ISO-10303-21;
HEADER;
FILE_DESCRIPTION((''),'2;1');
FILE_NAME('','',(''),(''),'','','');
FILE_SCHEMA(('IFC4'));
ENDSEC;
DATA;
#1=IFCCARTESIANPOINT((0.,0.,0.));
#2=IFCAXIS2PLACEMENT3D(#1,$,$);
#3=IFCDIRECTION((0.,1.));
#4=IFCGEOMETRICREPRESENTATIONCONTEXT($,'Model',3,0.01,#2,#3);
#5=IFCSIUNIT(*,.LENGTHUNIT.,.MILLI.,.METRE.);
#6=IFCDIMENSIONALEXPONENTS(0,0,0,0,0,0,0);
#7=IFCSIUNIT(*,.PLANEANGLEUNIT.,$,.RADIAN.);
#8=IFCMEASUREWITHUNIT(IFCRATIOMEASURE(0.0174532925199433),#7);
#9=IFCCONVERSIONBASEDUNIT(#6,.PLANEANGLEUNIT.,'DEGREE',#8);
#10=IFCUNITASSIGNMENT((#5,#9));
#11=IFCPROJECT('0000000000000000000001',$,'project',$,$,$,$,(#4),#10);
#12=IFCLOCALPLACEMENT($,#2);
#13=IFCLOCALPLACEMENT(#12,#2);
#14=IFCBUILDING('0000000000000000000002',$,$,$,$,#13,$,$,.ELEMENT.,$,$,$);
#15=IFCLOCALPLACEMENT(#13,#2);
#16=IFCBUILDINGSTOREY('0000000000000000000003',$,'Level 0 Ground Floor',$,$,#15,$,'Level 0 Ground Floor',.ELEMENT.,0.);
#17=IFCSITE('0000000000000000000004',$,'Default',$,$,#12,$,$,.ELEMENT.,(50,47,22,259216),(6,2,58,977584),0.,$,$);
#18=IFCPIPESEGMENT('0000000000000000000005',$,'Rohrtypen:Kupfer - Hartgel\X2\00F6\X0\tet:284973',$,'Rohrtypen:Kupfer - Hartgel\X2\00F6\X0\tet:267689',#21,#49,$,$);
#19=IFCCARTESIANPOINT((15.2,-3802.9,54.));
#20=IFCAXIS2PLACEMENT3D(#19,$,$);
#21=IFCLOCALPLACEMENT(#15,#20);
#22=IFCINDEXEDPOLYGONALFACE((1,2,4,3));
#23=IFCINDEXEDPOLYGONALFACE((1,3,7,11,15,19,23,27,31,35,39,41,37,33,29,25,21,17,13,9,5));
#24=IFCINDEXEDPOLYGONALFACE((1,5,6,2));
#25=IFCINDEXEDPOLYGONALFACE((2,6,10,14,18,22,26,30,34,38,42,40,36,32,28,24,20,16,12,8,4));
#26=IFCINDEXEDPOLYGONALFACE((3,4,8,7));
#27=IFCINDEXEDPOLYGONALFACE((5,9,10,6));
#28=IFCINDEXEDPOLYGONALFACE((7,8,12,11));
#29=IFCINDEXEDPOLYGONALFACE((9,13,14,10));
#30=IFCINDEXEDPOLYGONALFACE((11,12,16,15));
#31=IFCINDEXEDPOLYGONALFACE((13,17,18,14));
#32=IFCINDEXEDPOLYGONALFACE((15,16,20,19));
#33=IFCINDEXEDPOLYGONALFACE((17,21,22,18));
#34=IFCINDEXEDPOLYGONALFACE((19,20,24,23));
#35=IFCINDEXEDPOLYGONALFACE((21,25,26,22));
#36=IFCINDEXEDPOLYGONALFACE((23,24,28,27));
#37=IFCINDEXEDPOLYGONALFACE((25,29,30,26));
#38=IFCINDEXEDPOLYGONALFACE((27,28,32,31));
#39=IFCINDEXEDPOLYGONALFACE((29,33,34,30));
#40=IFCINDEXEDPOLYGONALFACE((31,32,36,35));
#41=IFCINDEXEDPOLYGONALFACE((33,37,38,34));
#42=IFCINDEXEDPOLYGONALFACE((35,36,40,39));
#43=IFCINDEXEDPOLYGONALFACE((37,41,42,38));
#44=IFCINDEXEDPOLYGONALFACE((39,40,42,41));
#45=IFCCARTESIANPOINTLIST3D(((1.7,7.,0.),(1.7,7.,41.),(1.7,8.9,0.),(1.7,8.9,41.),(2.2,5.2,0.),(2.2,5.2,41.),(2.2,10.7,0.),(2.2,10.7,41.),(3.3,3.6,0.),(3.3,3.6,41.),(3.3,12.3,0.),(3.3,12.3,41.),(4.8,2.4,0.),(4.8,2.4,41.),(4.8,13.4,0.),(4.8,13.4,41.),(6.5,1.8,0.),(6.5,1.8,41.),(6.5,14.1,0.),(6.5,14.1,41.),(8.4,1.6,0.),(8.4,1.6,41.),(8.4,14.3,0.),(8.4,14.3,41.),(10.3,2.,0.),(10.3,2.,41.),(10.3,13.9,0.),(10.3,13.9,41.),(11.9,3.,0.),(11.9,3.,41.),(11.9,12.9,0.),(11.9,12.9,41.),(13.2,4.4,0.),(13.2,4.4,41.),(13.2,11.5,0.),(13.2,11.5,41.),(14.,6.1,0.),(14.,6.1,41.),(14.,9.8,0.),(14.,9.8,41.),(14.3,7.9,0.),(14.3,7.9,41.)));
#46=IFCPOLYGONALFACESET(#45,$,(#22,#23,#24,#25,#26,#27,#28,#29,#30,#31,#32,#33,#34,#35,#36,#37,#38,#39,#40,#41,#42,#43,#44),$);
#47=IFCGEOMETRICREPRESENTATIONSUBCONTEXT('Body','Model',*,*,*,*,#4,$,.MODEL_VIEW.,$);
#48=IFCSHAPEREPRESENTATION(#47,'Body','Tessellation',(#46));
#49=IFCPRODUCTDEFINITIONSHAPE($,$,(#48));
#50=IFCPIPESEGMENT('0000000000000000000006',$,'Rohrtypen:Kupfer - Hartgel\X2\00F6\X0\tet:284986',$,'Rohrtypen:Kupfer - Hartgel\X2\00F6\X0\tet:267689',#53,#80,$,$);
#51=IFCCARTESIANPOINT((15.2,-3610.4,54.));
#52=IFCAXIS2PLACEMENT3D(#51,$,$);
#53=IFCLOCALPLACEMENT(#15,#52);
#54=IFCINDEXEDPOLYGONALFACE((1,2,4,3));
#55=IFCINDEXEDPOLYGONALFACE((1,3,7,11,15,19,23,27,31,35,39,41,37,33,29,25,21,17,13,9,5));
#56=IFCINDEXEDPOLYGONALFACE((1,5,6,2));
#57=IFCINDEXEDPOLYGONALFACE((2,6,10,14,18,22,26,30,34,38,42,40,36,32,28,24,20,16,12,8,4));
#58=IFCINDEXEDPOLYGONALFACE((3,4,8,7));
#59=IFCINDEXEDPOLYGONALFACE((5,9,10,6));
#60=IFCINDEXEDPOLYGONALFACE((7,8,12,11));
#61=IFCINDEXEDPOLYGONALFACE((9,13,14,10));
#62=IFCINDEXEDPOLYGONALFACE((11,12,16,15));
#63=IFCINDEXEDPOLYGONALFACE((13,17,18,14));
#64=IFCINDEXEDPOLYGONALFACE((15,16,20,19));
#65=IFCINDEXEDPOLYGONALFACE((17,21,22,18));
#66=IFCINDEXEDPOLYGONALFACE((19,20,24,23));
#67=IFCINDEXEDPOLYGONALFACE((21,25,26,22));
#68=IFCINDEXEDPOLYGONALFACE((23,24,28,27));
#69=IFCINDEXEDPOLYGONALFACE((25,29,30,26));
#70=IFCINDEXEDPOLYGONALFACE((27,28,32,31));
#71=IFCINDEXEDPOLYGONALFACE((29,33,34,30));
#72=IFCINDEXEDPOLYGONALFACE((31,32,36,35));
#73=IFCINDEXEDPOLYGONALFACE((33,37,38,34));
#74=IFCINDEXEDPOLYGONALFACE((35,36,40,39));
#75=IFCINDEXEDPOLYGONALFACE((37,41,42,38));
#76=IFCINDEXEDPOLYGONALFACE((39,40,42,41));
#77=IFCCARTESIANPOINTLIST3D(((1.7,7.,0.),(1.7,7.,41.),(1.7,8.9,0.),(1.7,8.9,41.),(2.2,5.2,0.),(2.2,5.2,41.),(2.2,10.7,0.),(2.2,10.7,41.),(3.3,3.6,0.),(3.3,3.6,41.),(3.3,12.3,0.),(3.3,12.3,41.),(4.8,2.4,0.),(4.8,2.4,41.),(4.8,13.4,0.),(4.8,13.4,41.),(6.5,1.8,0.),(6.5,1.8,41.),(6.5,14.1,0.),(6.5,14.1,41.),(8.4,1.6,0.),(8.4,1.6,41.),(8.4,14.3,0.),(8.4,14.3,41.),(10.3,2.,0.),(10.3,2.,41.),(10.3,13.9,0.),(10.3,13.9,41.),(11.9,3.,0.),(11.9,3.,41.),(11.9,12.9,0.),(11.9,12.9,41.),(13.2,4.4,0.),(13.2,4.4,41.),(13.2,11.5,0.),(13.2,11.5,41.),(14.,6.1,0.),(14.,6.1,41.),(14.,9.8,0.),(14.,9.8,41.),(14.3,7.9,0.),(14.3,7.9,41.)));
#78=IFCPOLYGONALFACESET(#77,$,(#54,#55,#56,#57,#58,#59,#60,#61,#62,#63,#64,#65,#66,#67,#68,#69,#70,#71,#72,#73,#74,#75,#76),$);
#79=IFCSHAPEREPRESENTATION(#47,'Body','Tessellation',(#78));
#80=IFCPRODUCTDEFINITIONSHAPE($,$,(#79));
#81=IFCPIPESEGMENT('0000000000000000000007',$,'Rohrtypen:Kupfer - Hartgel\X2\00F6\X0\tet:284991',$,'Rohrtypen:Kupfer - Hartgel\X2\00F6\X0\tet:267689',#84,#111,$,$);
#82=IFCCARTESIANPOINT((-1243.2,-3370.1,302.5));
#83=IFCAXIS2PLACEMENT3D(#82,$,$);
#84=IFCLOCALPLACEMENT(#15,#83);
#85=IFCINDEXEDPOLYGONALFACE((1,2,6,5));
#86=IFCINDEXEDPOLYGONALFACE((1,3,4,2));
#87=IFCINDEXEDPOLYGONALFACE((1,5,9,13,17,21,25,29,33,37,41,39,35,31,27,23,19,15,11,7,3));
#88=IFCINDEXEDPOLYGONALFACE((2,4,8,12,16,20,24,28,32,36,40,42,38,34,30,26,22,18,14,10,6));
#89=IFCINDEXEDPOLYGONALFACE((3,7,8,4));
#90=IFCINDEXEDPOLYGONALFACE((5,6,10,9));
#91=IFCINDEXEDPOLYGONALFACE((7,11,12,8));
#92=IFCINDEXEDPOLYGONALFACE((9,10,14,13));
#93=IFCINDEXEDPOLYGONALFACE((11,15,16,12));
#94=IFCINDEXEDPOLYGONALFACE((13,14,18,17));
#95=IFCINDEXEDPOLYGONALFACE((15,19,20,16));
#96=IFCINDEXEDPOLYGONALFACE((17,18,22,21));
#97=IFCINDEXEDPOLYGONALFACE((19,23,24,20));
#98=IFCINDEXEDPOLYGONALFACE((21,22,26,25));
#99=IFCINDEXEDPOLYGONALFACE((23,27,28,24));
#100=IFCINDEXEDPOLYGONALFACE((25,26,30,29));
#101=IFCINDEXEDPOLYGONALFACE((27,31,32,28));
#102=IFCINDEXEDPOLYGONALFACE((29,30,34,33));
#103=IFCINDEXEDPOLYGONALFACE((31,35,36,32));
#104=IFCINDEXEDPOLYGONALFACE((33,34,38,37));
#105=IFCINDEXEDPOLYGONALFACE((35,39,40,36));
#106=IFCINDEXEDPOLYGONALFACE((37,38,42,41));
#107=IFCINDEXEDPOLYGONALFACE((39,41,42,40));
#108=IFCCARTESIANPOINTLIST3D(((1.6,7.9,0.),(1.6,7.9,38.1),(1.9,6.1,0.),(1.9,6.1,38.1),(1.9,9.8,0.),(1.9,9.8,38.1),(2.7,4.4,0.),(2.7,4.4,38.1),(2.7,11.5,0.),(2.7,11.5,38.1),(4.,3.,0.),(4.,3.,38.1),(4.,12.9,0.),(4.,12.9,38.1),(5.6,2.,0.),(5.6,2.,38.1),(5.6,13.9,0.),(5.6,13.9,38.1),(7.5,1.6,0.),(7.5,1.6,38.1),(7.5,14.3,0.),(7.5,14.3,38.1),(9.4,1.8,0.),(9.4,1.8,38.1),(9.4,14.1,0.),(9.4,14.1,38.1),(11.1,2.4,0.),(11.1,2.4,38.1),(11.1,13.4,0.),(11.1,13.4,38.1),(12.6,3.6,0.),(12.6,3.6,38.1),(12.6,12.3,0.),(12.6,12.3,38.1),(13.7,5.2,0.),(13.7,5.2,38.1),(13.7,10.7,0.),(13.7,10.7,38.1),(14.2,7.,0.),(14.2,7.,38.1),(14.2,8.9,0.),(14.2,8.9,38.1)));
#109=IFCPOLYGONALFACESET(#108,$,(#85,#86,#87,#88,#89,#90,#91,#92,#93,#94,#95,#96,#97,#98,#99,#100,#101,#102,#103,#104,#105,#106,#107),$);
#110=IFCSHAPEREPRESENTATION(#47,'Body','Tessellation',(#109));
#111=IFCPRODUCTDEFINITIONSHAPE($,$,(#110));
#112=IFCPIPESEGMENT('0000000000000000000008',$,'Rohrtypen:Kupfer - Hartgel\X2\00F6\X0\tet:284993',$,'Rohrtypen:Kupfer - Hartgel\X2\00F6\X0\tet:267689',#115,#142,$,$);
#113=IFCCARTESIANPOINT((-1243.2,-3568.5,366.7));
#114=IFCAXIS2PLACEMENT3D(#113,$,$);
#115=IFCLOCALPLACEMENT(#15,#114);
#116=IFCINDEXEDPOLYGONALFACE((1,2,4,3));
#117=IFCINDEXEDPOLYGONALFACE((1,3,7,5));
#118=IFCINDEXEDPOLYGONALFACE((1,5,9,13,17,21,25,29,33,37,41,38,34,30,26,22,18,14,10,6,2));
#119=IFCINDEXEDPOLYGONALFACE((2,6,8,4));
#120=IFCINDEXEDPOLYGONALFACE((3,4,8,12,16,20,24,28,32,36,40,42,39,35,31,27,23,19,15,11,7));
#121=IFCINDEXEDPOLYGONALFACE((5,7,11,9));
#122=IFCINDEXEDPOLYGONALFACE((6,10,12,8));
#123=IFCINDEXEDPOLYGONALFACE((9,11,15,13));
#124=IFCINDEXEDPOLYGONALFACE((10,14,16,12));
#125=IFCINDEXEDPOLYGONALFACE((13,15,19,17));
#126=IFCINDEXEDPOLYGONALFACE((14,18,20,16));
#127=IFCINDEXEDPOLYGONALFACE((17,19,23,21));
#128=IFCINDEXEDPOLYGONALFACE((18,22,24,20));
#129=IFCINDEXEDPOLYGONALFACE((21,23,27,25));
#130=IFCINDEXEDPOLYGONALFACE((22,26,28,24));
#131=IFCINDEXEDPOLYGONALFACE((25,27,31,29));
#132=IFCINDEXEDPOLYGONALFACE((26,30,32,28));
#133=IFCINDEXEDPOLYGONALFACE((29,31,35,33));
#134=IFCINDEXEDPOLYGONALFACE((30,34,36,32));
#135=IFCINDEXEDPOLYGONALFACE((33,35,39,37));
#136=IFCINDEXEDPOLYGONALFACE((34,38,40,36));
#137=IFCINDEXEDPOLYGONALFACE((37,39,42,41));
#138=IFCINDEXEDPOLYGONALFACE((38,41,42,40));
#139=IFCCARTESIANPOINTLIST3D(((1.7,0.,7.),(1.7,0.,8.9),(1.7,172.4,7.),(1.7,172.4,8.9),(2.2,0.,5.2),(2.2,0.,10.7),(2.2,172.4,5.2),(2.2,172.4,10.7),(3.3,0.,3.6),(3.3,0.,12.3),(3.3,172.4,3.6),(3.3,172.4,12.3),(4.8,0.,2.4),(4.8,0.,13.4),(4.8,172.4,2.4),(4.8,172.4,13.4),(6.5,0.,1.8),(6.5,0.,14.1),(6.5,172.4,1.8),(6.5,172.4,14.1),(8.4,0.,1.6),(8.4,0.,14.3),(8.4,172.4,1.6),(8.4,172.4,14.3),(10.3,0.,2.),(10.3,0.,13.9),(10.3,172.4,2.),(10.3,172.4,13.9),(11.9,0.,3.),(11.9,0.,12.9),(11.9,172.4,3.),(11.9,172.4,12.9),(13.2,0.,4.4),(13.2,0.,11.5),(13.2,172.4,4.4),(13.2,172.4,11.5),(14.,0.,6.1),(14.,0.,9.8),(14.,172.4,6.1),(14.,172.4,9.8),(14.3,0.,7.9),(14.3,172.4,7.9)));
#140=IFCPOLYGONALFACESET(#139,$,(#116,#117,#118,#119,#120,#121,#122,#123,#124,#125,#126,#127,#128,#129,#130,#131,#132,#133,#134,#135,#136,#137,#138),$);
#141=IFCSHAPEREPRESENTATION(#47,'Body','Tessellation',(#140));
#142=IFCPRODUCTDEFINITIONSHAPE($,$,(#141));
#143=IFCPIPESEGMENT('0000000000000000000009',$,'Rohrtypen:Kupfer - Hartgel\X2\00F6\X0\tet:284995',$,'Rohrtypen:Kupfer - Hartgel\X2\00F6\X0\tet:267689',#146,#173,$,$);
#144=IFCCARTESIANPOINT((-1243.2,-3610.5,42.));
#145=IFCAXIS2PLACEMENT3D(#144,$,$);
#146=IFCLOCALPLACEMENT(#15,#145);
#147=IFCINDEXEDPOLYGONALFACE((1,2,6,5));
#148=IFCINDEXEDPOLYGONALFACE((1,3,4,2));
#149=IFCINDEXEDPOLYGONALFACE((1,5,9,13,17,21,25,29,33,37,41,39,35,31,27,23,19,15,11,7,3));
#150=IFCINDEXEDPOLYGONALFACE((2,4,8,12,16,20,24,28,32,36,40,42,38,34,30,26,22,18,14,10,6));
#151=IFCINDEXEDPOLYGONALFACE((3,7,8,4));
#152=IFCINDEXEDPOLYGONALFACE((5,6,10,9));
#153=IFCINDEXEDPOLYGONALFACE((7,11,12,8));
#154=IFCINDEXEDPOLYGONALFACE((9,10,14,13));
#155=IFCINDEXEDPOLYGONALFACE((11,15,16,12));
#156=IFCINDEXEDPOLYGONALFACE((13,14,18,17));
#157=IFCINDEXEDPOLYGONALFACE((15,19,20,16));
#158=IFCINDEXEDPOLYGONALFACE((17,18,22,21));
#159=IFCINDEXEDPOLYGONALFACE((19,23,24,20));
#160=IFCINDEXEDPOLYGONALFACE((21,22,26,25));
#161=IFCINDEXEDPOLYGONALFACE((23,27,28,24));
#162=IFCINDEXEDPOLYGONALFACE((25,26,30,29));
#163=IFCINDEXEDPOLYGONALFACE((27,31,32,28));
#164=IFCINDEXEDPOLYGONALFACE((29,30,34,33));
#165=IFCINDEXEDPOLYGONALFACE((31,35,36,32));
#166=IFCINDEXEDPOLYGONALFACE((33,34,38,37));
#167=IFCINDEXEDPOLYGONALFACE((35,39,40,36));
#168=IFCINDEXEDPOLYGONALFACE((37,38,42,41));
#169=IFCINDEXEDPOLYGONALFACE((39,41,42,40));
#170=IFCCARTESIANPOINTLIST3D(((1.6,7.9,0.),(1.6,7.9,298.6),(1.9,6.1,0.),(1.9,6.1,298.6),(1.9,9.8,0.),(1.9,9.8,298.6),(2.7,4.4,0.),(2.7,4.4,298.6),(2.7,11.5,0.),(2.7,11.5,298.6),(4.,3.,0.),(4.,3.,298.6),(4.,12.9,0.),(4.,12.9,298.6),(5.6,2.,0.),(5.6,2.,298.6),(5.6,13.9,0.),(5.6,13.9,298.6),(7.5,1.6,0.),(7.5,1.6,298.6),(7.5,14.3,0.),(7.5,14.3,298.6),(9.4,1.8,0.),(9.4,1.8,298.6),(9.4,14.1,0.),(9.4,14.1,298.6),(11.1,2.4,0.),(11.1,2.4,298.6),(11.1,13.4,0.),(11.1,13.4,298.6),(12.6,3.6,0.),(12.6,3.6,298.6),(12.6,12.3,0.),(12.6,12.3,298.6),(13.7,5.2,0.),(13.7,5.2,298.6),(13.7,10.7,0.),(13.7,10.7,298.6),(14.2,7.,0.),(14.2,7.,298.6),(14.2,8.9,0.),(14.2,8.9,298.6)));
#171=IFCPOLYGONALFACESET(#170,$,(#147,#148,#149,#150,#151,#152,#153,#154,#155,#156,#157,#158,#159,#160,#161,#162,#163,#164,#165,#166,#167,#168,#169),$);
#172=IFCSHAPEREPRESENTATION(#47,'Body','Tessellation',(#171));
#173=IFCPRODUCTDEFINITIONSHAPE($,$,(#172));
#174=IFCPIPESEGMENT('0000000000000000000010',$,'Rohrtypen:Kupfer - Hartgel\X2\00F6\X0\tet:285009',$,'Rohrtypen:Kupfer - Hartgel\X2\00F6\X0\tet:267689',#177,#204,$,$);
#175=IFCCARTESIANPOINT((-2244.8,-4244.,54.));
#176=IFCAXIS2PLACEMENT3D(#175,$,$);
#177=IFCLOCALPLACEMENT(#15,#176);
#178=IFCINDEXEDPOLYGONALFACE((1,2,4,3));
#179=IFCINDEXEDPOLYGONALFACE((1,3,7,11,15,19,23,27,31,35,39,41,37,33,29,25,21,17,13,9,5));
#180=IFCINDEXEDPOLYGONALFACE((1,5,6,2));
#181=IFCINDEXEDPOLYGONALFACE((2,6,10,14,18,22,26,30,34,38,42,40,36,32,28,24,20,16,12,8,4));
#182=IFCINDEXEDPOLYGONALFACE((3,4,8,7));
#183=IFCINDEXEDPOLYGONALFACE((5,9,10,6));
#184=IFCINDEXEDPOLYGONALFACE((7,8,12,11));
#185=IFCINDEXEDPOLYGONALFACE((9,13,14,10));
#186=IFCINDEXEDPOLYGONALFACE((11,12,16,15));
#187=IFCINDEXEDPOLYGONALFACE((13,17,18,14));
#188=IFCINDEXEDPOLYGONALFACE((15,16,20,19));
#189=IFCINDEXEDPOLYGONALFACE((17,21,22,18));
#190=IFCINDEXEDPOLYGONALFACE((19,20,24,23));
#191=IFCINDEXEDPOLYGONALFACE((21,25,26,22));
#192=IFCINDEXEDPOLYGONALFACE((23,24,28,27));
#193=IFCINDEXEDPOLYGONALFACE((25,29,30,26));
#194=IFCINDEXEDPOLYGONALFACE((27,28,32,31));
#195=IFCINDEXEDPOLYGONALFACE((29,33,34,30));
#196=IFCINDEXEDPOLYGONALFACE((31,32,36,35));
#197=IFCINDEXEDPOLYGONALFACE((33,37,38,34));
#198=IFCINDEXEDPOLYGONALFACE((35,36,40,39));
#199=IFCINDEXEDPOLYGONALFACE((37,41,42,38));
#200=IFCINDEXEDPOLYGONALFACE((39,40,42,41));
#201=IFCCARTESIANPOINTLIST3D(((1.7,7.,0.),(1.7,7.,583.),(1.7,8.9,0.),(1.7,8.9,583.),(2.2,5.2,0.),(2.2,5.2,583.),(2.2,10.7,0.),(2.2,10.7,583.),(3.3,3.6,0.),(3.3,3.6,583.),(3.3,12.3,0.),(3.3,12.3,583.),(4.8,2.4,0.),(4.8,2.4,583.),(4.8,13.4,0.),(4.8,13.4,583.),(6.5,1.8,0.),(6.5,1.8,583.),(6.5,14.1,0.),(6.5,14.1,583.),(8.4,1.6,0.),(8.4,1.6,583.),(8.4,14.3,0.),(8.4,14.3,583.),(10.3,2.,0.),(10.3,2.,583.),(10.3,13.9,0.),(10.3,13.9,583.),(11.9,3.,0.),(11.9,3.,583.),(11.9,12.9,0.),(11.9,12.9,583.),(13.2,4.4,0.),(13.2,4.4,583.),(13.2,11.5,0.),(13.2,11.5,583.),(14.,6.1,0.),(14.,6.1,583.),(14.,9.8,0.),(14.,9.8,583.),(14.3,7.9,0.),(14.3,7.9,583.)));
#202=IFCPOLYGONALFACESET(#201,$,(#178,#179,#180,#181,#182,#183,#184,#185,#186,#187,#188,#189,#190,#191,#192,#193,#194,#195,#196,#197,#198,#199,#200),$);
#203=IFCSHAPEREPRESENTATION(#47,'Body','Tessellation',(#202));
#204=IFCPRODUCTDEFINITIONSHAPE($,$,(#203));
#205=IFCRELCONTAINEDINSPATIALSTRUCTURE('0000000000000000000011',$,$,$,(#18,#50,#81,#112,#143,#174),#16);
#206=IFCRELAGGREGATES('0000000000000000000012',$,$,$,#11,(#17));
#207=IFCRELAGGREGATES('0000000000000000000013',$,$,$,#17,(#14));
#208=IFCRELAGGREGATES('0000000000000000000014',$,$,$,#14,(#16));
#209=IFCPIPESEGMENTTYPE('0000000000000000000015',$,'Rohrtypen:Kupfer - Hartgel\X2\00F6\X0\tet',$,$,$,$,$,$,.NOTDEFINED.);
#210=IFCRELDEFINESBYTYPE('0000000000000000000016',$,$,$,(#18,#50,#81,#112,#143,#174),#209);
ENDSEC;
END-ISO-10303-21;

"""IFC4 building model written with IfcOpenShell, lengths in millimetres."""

from ifc_helpers import new_model, entity, si_unit, converted_unit, direction, frame, frame_2d, origin, origin_2d_with_axis, place, context, subcontext, project, spatial, circle, extrude, type_object, element, save


model = new_model("IFC4")

# Units and contexts
model_context = context("Model", 3, precision=0.01, world=origin(), true_north=direction((0.0, 1.0)))
body_context = subcontext(model_context, "Body", "Model", "MODEL_VIEW")
ifc_project = project(units=[si_unit("LENGTHUNIT", "METRE", prefix="MILLI"), converted_unit("PLANEANGLEUNIT", "DEGREE", entity("IfcRatioMeasure", 0.0174532925199433), si_unit("PLANEANGLEUNIT", "RADIAN"), dimensions=[0, 0, 0, 0, 0, 0, 0])], contexts=[model_context])

# Site, building, storey
site_placement = place(None, origin())
site = spatial("IfcSite", under=ifc_project, at=site_placement, Name="Default", CompositionType="ELEMENT", RefLatitude=(50, 47, 22, 259216), RefLongitude=(6, 2, 58, 977584), RefElevation=0.0)
building_placement = place(site_placement, origin())
building = spatial("IfcBuilding", under=site, at=building_placement, CompositionType="ELEMENT")
storey_placement = place(building_placement, origin())
storey = spatial("IfcBuildingStorey", under=building, at=storey_placement, Name="Level 0 Ground Floor", LongName="Level 0 Ground Floor", CompositionType="ELEMENT", Elevation=0.0)

# Pipe segments
pipe_segment_type = type_object("IfcPipeSegmentType", Name="Rohrtypen:Kupfer - Hartgelötet", PredefinedType="NOTDEFINED")
pipe_segment_1_placement = place(storey_placement, frame((15.2, -3802.9, 54.0)))
element("IfcPipeSegment", 1, at=pipe_segment_1_placement, inside=storey, type_object=pipe_segment_type, Name="Rohrtypen:Kupfer - Hartgelötet:284973", ObjectType="Rohrtypen:Kupfer - Hartgelötet:267689", context=body_context, shape_type="SweptSolid", body=[
    extrude(circle(Radius=6.3, at=frame_2d((0.0, 0.0), x_axis=(1.0, 0.0))), frame((7.9, 7.9, 0.0)), (0.0, 0.0, 1.0), 41.0),
])
pipe_segment_2_placement = place(storey_placement, frame((15.2, -3610.4, 54.0)))
element("IfcPipeSegment", 2, at=pipe_segment_2_placement, inside=storey, type_object=pipe_segment_type, Name="Rohrtypen:Kupfer - Hartgelötet:284986", ObjectType="Rohrtypen:Kupfer - Hartgelötet:267689", context=body_context, shape_type="SweptSolid", body=[
    extrude(circle(Radius=6.3, at=frame_2d((0.0, 0.0), x_axis=(1.0, 0.0))), frame((7.9, 7.9, 0.0)), (0.0, 0.0, 1.0), 41.0),
])
pipe_segment_3_placement = place(storey_placement, frame((-1243.2, -3370.1, 302.5)))
element("IfcPipeSegment", 3, at=pipe_segment_3_placement, inside=storey, type_object=pipe_segment_type, Name="Rohrtypen:Kupfer - Hartgelötet:284991", ObjectType="Rohrtypen:Kupfer - Hartgelötet:267689", context=body_context, shape_type="SweptSolid", body=[
    extrude(circle(Radius=6.3, at=origin_2d_with_axis()), frame((7.9, 7.9, 0.0), z_axis=(0.0, 0.0, 1.0), x_axis=(-1.0, 0.0, 0.0)), (0.0, 0.0, 1.0), 38.1),
])
pipe_segment_4_placement = place(storey_placement, frame((-1243.2, -3568.5, 366.7)))
element("IfcPipeSegment", 4, at=pipe_segment_4_placement, inside=storey, type_object=pipe_segment_type, Name="Rohrtypen:Kupfer - Hartgelötet:284993", ObjectType="Rohrtypen:Kupfer - Hartgelötet:267689", context=body_context, shape_type="SweptSolid", body=[
    extrude(circle(Radius=6.3, at=origin_2d_with_axis()), frame((7.9, 0.0, 7.9), z_axis=(0.0, 1.0, 0.0), x_axis=(1.0, 0.0, 0.0)), (0.0, 0.0, 1.0), 172.4),
])
pipe_segment_5_placement = place(storey_placement, frame((-1243.2, -3610.5, 42.0)))
element("IfcPipeSegment", 5, at=pipe_segment_5_placement, inside=storey, type_object=pipe_segment_type, Name="Rohrtypen:Kupfer - Hartgelötet:284995", ObjectType="Rohrtypen:Kupfer - Hartgelötet:267689", context=body_context, shape_type="SweptSolid", body=[
    extrude(circle(Radius=6.3, at=frame_2d((0.0, 0.0), x_axis=(1.0, 0.0))), frame((7.9, 7.9, 0.0), z_axis=(0.0, 0.0, 1.0), x_axis=(-1.0, 0.0, 0.0)), (0.0, 0.0, 1.0), 298.6),
])
pipe_segment_6_placement = place(storey_placement, frame((-2244.8, -4244.0, 54.0)))
element("IfcPipeSegment", 6, at=pipe_segment_6_placement, inside=storey, type_object=pipe_segment_type, Name="Rohrtypen:Kupfer - Hartgelötet:285009", ObjectType="Rohrtypen:Kupfer - Hartgelötet:267689", context=body_context, shape_type="SweptSolid", body=[
    extrude(circle(Radius=6.3, at=frame_2d((0.0, 0.0), x_axis=(1.0, 0.0))), frame((7.9, 7.9, 0.0)), (0.0, 0.0, 1.0), 583.0),
])

save(model, "model.ifc")
